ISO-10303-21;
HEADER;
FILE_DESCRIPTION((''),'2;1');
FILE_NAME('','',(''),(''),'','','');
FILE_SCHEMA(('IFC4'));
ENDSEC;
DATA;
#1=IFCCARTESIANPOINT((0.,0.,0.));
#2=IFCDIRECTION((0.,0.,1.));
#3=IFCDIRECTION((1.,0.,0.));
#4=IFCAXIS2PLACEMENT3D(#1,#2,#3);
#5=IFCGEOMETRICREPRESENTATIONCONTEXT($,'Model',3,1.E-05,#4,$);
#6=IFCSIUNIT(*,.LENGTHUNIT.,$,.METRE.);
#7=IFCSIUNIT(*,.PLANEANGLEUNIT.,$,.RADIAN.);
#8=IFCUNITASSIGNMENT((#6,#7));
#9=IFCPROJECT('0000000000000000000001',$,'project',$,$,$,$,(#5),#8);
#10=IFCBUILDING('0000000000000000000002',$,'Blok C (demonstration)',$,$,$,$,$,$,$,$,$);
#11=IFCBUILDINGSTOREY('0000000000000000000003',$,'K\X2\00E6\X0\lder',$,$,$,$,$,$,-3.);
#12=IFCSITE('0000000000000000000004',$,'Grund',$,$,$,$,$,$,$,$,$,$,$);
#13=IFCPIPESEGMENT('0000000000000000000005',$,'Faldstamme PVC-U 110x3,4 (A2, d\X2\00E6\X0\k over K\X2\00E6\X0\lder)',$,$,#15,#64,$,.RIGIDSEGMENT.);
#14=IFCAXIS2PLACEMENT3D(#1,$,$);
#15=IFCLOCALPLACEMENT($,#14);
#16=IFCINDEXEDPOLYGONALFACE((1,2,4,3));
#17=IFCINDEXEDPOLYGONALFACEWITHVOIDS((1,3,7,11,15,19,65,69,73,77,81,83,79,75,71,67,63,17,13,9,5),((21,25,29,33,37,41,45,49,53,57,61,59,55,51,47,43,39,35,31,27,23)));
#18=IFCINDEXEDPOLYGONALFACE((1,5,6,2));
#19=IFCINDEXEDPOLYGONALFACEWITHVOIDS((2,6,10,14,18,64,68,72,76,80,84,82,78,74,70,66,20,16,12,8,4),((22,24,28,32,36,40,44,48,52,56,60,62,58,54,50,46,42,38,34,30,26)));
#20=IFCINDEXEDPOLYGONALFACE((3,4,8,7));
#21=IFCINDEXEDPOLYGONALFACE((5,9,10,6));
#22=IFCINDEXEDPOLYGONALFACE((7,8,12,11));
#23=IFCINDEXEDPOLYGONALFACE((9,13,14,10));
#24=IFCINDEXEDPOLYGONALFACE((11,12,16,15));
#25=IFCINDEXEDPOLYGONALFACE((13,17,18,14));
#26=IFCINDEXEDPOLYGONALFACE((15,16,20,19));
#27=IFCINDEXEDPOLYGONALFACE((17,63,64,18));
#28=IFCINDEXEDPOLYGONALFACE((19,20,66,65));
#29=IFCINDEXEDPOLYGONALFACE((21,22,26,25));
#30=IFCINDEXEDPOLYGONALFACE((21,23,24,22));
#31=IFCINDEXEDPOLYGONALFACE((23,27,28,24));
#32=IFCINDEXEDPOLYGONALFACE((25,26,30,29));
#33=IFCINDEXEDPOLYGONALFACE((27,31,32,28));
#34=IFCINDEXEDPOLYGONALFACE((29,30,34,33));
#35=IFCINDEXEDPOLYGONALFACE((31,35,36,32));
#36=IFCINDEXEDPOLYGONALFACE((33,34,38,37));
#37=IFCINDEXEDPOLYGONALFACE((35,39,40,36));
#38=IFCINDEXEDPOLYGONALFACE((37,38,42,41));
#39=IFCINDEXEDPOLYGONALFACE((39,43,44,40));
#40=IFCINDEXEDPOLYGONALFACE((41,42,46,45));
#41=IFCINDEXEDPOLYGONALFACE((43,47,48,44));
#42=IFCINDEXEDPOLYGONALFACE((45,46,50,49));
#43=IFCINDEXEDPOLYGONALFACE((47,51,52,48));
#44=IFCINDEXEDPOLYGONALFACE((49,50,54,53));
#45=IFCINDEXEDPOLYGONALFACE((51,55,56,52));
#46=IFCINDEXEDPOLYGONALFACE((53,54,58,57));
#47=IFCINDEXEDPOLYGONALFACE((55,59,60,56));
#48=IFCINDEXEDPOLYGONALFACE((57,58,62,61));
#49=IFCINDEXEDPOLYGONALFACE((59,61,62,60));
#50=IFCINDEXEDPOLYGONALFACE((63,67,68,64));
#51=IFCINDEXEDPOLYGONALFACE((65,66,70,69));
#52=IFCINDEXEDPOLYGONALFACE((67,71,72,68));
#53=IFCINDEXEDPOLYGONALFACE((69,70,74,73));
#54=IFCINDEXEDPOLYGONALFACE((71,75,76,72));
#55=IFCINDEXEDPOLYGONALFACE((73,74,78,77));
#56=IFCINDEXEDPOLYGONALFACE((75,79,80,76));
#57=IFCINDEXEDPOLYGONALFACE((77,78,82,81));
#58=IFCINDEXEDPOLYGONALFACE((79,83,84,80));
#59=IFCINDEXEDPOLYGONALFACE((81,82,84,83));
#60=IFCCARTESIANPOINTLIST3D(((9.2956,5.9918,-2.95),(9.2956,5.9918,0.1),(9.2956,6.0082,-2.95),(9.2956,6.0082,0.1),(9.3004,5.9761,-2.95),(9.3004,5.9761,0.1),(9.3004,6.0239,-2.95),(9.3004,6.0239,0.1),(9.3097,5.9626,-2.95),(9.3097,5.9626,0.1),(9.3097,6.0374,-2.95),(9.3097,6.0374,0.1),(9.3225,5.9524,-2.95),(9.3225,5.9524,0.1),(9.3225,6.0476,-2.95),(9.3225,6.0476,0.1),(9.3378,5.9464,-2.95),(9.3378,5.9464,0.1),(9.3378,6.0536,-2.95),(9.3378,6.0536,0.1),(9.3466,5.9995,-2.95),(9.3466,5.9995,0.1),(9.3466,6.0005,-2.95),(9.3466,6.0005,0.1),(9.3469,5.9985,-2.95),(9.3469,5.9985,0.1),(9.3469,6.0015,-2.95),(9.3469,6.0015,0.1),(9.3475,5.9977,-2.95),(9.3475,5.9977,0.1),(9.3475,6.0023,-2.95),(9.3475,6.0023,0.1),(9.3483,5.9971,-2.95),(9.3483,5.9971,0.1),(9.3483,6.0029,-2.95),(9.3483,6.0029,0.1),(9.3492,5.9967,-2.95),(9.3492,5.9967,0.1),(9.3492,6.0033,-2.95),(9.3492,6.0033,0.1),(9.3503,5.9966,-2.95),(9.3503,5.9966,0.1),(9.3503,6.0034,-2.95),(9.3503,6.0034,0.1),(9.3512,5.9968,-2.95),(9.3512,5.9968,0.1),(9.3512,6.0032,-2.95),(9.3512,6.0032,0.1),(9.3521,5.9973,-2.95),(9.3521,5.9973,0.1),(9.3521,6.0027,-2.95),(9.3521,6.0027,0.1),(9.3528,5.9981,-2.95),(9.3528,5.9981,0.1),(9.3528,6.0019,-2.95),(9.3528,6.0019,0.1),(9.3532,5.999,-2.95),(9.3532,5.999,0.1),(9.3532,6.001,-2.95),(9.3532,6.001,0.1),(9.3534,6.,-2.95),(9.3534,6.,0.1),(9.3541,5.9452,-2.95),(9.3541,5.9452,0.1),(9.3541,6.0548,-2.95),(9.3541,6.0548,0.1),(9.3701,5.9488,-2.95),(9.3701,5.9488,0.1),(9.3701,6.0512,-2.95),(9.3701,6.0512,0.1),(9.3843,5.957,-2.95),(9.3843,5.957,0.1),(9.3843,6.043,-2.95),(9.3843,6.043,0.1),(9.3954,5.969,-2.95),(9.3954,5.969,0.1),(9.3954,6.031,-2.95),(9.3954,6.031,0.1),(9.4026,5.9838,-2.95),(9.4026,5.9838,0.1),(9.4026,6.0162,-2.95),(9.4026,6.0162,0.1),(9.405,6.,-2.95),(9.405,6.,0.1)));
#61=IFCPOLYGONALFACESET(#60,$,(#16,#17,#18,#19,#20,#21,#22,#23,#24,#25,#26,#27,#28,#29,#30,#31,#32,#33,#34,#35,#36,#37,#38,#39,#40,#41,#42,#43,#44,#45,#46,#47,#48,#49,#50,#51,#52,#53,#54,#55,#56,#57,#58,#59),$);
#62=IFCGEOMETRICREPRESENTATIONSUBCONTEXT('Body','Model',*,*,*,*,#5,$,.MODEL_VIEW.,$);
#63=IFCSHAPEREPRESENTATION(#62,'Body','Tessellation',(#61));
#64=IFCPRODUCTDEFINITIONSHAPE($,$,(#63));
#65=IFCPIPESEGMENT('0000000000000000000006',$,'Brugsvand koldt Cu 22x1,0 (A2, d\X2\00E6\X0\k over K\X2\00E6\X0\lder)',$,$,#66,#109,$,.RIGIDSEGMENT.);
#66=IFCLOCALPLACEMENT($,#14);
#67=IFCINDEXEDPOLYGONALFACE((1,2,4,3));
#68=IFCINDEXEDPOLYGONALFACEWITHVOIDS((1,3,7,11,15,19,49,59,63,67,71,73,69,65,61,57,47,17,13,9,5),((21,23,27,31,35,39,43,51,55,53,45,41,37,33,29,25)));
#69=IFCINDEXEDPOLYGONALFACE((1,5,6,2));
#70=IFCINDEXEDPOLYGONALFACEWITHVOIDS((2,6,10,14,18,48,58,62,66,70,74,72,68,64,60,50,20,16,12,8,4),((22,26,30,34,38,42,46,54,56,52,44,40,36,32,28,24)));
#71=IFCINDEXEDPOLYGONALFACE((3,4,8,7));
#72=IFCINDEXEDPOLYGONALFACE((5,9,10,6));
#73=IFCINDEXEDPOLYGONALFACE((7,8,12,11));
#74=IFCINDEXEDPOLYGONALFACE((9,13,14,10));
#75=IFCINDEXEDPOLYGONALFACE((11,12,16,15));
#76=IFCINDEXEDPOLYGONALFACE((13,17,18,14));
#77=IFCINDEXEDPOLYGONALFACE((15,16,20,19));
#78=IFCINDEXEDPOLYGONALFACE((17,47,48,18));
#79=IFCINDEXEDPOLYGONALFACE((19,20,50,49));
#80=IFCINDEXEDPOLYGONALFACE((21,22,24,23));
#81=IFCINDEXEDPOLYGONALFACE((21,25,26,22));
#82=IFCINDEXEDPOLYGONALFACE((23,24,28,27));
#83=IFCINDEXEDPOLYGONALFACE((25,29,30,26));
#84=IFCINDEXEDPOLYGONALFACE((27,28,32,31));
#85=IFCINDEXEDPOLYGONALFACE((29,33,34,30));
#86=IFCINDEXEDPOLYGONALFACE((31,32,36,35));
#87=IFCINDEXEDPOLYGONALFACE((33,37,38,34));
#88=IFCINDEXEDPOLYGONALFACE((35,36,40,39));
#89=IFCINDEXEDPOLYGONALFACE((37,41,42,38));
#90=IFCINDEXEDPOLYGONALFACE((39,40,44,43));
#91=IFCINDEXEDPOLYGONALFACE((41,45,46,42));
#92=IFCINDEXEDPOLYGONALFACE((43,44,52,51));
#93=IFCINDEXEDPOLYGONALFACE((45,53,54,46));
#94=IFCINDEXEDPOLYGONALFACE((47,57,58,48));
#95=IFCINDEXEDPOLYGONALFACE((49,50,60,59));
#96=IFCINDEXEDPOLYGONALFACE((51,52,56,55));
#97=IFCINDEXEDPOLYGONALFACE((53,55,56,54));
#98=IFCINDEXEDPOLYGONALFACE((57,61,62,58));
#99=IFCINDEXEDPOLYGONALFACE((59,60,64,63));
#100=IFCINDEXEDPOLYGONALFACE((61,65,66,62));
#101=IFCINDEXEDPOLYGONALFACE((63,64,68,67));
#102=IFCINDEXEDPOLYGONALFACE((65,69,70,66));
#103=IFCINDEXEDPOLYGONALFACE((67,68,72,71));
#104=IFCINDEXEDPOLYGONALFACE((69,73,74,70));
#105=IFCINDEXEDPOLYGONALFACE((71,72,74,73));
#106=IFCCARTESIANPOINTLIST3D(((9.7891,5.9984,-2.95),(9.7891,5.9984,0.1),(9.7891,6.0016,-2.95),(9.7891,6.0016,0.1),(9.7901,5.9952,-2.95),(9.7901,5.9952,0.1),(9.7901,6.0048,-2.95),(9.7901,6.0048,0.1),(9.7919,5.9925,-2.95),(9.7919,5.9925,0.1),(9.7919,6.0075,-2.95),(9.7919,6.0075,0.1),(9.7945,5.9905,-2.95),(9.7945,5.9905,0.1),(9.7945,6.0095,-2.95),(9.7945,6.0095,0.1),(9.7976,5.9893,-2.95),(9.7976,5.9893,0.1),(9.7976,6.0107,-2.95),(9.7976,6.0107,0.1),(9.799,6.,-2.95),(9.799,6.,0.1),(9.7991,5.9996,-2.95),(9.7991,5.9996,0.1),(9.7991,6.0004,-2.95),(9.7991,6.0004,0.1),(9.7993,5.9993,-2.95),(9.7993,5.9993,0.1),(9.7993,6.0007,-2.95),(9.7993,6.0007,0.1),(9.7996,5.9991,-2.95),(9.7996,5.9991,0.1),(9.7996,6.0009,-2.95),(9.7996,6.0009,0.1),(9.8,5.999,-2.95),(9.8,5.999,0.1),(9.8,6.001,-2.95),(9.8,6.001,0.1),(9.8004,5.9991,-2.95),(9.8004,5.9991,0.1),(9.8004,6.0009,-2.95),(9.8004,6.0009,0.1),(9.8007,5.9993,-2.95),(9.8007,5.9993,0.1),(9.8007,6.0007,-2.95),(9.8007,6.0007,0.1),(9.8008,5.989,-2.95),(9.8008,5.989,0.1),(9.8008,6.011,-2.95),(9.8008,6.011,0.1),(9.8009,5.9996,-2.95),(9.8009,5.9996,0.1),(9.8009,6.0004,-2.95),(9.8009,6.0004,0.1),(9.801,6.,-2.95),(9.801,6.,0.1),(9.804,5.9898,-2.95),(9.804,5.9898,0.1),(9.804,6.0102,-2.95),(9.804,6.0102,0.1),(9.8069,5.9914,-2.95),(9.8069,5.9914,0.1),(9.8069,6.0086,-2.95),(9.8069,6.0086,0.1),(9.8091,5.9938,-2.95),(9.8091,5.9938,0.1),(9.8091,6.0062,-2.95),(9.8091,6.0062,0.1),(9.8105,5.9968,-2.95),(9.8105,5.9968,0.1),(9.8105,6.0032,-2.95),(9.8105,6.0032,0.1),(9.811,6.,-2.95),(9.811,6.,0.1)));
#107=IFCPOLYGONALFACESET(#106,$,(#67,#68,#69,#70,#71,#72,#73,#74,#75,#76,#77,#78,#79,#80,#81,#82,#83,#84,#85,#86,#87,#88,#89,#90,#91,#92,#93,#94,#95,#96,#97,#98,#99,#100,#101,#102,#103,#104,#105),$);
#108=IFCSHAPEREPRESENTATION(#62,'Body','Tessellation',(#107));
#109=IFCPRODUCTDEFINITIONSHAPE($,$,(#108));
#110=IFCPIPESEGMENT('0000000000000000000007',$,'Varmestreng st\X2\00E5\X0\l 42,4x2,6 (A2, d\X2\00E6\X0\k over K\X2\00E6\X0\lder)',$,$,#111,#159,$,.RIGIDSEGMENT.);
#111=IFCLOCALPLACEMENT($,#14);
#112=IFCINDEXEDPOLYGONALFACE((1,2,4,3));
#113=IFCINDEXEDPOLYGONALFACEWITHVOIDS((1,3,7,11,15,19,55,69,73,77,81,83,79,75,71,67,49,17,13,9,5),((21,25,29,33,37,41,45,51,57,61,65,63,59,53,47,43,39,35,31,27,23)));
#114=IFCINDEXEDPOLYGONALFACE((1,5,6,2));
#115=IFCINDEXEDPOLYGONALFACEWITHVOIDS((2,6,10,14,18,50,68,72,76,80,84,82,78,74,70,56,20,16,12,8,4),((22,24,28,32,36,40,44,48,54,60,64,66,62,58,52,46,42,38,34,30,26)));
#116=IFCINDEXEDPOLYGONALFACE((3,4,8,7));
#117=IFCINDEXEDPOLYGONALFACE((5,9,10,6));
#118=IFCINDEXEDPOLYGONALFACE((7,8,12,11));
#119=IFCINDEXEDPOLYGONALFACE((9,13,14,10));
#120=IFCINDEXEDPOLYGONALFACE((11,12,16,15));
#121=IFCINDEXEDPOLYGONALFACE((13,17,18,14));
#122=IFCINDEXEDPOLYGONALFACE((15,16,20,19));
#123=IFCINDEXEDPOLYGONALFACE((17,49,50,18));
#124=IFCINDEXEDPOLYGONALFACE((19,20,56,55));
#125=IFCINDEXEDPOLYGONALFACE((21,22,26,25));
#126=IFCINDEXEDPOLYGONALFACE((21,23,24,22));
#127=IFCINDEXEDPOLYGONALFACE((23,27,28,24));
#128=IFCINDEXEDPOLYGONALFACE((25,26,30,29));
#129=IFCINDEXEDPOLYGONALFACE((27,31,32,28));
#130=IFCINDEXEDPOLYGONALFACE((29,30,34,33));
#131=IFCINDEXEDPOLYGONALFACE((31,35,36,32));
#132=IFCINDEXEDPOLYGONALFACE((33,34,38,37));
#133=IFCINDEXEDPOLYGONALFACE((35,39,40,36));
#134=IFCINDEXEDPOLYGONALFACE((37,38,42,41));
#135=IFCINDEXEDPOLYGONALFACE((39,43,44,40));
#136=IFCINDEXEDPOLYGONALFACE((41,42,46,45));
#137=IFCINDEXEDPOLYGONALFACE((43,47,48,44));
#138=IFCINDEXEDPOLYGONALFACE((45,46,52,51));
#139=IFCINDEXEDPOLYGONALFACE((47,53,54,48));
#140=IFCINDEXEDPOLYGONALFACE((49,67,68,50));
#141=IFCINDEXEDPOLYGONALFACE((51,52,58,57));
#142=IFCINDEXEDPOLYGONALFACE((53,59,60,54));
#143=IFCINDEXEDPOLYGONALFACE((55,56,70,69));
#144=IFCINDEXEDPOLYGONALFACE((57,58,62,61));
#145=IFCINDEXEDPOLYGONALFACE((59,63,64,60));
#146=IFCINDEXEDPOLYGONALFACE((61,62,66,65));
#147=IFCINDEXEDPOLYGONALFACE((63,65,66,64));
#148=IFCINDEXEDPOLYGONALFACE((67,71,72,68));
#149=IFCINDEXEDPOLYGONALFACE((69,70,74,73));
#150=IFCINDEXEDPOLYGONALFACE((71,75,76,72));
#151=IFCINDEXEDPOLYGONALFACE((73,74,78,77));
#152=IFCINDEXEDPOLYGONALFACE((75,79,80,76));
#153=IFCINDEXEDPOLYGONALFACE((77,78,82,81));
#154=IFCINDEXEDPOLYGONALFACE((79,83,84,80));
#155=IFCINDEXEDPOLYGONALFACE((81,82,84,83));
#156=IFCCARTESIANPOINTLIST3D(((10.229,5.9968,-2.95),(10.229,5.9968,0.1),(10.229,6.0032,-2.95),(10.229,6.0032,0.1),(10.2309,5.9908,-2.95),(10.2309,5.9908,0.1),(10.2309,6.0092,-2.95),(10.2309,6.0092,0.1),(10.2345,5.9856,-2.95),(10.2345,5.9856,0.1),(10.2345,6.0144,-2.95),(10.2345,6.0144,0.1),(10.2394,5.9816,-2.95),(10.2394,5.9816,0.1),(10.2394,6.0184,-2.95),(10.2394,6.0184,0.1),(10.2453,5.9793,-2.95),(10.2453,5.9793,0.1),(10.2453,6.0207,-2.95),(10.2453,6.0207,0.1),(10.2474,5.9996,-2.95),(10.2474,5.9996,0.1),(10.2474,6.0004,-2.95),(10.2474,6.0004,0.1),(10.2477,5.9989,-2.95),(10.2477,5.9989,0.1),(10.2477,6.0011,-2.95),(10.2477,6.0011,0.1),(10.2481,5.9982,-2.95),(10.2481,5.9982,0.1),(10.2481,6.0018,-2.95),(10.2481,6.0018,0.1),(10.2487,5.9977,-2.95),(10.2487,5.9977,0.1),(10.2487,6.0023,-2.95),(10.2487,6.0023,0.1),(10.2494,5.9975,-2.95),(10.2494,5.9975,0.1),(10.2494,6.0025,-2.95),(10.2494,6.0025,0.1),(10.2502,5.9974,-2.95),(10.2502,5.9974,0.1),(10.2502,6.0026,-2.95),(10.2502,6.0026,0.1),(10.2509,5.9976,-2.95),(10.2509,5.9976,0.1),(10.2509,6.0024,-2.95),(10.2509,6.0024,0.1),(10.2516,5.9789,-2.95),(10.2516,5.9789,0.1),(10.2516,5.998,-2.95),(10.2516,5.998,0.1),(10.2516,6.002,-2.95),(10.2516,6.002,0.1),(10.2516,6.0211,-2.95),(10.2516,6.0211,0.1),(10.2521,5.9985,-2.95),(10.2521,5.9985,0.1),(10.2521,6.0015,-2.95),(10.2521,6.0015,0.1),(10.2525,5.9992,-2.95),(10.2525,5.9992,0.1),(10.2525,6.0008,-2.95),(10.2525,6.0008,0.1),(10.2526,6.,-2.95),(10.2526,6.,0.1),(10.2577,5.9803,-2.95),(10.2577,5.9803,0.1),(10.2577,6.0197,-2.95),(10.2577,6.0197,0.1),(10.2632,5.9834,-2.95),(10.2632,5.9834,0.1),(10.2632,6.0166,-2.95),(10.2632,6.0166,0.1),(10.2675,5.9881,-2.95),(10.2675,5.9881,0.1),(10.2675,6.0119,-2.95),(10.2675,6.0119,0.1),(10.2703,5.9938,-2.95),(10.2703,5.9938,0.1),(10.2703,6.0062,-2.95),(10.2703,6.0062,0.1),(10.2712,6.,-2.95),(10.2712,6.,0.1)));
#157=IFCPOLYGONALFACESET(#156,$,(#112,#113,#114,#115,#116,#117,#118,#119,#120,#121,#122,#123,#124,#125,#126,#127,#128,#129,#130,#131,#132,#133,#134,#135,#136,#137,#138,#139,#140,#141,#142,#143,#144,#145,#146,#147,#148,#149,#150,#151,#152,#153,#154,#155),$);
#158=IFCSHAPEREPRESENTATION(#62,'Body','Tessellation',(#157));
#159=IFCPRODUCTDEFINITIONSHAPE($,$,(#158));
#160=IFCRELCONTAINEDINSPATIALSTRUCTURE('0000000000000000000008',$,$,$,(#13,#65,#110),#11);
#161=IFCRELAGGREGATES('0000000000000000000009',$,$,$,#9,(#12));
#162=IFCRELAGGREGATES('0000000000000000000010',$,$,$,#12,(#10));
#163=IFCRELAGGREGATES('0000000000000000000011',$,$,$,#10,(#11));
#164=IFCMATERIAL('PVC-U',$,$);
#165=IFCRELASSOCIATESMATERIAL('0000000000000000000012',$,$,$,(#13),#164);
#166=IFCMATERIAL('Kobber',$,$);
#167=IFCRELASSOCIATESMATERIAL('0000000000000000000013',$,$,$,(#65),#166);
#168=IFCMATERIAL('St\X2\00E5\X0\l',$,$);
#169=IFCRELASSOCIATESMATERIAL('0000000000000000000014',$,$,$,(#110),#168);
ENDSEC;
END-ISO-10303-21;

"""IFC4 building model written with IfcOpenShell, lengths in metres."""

from ifc_helpers import new_model, si_unit, frame, origin_with_axes, place, context, subcontext, project, spatial, hollow_circle, extrude, material, element, save


model = new_model("IFC4")

# Units and contexts
model_context = context("Model", 3, precision=1e-05, world=origin_with_axes())
body_context = subcontext(model_context, "Body", "Model", "MODEL_VIEW")
ifc_project = project(units=[si_unit("LENGTHUNIT", "METRE"), si_unit("PLANEANGLEUNIT", "RADIAN")], contexts=[model_context])

# Site, building, storey
site = spatial("IfcSite", under=ifc_project, Name="Grund")
building = spatial("IfcBuilding", under=site, Name="Blok C (demonstration)")
storey = spatial("IfcBuildingStorey", under=building, Name="Kælder", Elevation=-3.0)

# Pipe segments
ifc_material_1 = material(Name="PVC-U")
ifc_material_2 = material(Name="Kobber")
ifc_material_3 = material(Name="Stål")
pipe_segment_1_placement = place(None, origin_with_axes())
element("IfcPipeSegment", 1, at=pipe_segment_1_placement, inside=storey, material=ifc_material_1, Name="Faldstamme PVC-U 110x3,4 (A2, dæk over Kælder)", PredefinedType="RIGIDSEGMENT", context=body_context, shape_type="SweptSolid", body=[
    extrude(hollow_circle(Radius=0.055, WallThickness=0.0516), frame((9.35, 6.0, -2.95), z_axis=(0.0, 0.0, 1.0), x_axis=(1.0, 0.0, 0.0)), (0.0, 0.0, 1.0), 3.05),
])
pipe_segment_2_placement = place(None, origin_with_axes())
element("IfcPipeSegment", 2, at=pipe_segment_2_placement, inside=storey, material=ifc_material_2, Name="Brugsvand koldt Cu 22x1,0 (A2, dæk over Kælder)", PredefinedType="RIGIDSEGMENT", context=body_context, shape_type="SweptSolid", body=[
    extrude(hollow_circle(Radius=0.011, WallThickness=0.01), frame((9.8, 6.0, -2.95), z_axis=(0.0, 0.0, 1.0), x_axis=(1.0, 0.0, 0.0)), (0.0, 0.0, 1.0), 3.05),
])
pipe_segment_3_placement = place(None, origin_with_axes())
element("IfcPipeSegment", 3, at=pipe_segment_3_placement, inside=storey, material=ifc_material_3, Name="Varmestreng stål 42,4x2,6 (A2, dæk over Kælder)", PredefinedType="RIGIDSEGMENT", context=body_context, shape_type="SweptSolid", body=[
    extrude(hollow_circle(Radius=0.0212, WallThickness=0.0186), frame((10.25, 6.0, -2.95), z_axis=(0.0, 0.0, 1.0), x_axis=(1.0, 0.0, 0.0)), (0.0, 0.0, 1.0), 3.05),
])

save(model, "model.ifc")
